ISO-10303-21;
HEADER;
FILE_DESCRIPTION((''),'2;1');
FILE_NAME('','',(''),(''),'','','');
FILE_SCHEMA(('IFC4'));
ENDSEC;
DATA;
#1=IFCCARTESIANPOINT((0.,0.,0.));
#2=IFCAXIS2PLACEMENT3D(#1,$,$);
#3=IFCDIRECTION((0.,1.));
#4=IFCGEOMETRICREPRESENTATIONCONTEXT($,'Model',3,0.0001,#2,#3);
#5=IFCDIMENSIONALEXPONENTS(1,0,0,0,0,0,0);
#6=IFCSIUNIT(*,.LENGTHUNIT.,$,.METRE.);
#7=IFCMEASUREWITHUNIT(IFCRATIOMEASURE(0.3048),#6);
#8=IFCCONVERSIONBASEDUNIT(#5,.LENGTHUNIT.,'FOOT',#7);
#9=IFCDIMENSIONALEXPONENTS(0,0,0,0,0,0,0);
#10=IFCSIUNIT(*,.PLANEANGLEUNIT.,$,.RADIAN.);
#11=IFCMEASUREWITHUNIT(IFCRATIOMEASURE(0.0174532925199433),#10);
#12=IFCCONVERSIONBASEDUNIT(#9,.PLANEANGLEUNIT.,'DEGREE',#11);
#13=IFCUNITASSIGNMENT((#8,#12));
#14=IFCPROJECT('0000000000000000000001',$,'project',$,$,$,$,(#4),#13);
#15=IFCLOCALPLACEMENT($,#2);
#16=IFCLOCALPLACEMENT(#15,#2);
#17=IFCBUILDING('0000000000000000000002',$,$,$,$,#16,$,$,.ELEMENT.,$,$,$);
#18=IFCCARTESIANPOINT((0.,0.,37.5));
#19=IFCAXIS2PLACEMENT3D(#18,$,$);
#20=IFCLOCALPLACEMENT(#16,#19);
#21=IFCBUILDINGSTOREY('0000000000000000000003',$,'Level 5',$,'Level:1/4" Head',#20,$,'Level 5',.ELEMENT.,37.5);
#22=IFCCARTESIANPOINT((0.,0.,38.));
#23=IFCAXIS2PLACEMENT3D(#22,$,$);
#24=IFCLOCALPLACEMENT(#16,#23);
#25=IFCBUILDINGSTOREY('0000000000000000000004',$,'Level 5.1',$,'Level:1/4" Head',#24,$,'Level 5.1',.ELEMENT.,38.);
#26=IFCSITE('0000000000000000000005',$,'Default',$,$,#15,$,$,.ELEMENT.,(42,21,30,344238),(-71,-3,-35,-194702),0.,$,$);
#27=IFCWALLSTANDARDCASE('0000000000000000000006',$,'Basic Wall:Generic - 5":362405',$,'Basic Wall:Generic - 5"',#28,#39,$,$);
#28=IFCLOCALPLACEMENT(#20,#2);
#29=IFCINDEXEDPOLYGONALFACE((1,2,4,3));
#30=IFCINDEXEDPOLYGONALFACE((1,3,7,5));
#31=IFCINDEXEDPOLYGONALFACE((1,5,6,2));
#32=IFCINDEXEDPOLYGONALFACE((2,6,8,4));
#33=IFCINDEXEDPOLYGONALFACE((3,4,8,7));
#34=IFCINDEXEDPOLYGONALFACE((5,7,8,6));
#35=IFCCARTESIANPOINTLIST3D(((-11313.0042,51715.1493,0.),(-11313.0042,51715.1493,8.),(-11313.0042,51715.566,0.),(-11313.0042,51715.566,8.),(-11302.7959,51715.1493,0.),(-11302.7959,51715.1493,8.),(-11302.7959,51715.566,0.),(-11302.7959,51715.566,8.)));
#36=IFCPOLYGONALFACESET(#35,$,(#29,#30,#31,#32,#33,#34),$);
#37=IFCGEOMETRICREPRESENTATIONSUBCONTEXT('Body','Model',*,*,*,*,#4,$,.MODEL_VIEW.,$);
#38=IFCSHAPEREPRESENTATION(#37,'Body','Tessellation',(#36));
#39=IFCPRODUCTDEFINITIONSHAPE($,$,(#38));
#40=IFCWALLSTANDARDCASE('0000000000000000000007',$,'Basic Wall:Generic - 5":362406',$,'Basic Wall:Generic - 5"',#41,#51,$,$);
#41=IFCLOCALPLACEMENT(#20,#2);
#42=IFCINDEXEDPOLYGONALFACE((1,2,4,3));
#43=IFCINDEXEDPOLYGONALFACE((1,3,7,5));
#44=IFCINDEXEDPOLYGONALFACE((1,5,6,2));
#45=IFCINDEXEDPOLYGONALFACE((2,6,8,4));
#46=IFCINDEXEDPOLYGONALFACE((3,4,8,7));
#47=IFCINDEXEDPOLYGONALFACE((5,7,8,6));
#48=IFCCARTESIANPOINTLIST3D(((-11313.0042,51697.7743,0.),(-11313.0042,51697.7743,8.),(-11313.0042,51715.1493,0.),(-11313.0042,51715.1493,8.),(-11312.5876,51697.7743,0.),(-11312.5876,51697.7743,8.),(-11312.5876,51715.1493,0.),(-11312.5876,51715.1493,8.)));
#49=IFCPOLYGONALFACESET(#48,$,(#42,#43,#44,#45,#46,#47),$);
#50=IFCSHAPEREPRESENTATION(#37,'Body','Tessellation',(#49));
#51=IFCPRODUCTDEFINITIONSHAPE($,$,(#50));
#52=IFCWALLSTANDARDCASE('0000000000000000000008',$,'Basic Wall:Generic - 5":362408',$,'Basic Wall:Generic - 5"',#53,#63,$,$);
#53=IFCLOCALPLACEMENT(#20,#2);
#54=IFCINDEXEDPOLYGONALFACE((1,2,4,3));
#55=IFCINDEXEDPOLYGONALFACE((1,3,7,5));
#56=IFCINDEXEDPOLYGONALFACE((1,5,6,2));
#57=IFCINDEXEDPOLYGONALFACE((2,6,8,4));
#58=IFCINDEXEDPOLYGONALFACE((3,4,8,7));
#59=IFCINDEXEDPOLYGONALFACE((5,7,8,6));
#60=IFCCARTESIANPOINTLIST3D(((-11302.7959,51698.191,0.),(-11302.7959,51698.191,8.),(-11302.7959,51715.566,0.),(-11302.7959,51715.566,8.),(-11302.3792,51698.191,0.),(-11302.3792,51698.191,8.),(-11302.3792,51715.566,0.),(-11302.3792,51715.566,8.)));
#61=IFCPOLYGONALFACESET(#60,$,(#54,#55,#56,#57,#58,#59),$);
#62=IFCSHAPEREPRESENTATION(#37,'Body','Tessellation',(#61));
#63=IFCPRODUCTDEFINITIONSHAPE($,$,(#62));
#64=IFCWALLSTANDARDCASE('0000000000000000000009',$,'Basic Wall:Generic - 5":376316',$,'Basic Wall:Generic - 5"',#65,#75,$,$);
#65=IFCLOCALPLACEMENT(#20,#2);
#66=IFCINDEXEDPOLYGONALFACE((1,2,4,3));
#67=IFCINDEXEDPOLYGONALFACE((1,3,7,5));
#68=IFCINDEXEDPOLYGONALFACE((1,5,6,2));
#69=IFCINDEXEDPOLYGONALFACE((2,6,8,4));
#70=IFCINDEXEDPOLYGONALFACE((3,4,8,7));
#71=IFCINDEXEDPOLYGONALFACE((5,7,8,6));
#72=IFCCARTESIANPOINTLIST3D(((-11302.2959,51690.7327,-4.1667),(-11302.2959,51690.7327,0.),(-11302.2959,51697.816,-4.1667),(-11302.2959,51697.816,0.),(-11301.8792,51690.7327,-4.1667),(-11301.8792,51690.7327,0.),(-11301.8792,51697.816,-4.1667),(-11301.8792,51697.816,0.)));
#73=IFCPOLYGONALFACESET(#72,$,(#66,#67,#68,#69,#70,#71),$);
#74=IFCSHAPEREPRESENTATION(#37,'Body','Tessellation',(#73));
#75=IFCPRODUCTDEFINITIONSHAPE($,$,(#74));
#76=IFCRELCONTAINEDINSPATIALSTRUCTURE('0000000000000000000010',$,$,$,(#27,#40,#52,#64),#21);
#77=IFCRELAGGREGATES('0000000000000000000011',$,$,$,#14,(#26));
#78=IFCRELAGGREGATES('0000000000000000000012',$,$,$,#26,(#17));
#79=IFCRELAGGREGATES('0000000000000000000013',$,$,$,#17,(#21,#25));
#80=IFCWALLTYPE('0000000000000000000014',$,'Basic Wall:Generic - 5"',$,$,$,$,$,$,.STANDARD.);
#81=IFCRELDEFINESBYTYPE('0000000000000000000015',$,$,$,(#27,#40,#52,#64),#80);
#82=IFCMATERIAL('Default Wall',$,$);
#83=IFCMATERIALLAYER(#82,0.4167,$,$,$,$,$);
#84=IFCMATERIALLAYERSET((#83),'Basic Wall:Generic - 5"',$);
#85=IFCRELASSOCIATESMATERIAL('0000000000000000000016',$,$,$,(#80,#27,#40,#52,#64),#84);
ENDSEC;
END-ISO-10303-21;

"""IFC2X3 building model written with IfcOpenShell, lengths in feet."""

from ifc_helpers import new_model, entity, si_unit, converted_unit, direction, frame, frame_2d, origin, place, context, subcontext, project, spatial, rectangle, extrude, material, layer, layer_set, layer_usage, type_object, element, save


model = new_model("IFC2X3")

# Units and contexts
model_context = context("Model", 3, precision=0.0001, world=origin(), true_north=direction((0.0, 1.0)))
body_context = subcontext(model_context, "Body", "Model", "MODEL_VIEW")
ifc_project = project(units=[converted_unit("LENGTHUNIT", "FOOT", entity("IfcRatioMeasure", 0.3048), si_unit("LENGTHUNIT", "METRE"), dimensions=[1, 0, 0, 0, 0, 0, 0]), converted_unit("PLANEANGLEUNIT", "DEGREE", entity("IfcRatioMeasure", 0.0174532925199433), si_unit("PLANEANGLEUNIT", "RADIAN"), dimensions=[0, 0, 0, 0, 0, 0, 0])], contexts=[model_context])

# Site, building, storey
site_placement = place(None, origin())
site = spatial("IfcSite", under=ifc_project, at=site_placement, Name="Default", CompositionType="ELEMENT", RefLatitude=(42, 21, 30, 344238), RefLongitude=(-71, -3, -35, -194702), RefElevation=0.0)
building_placement = place(site_placement, origin())
building = spatial("IfcBuilding", under=site, at=building_placement, CompositionType="ELEMENT")
storey_1_placement = place(building_placement, frame((0.0, 0.0, 37.5)))
storey_1 = spatial("IfcBuildingStorey", under=building, at=storey_1_placement, Name="Level 5", ObjectType="Level:1/4\" Head", LongName="Level 5", CompositionType="ELEMENT", Elevation=37.5)

# Walls
ifc_material_1 = material(Name="Default Wall")
ifc_layer = layer(ifc_material_1, 0.4167)
ifc_layer_set = layer_set([ifc_layer], Name="Basic Wall:Generic - 5\"")
ifc_layer_usage_1 = layer_usage(ifc_layer_set, "AXIS2", "POSITIVE", -0.2083)
wall_type = type_object("IfcWallType", Name="Basic Wall:Generic - 5\"", PredefinedType="STANDARD", material=ifc_layer_set)
wall_1_placement = place(storey_1_placement, frame((-11313.0042, 51715.3577, 0.0)))
element("IfcWallStandardCase", 1, at=wall_1_placement, inside=storey_1, type_object=wall_type, material=ifc_layer_usage_1, Name="Basic Wall:Generic - 5\":362405", ObjectType="Basic Wall:Generic - 5\"", context=body_context, shape_type="SweptSolid", body=[
    extrude(rectangle(XDim=10.2083, YDim=0.4167, at=frame_2d((5.1042, 0.0), x_axis=(-1.0, 0.0))), origin(), (0.0, 0.0, 1.0), 8.0),
])
ifc_layer_usage_2 = layer_usage(ifc_layer_set, "AXIS2", "POSITIVE", -0.2083)
wall_2_placement = place(storey_1_placement, frame((-11312.7959, 51697.7743, 0.0), z_axis=(0.0, 0.0, 1.0), x_axis=(0.0, 1.0, 0.0)))
element("IfcWallStandardCase", 2, at=wall_2_placement, inside=storey_1, type_object=wall_type, material=ifc_layer_usage_2, Name="Basic Wall:Generic - 5\":362406", ObjectType="Basic Wall:Generic - 5\"", context=body_context, shape_type="SweptSolid", body=[
    extrude(rectangle(XDim=17.375, YDim=0.4167, at=frame_2d((8.6875, 0.0), x_axis=(-1.0, 0.0))), origin(), (0.0, 0.0, 1.0), 8.0),
])

# Shared definitions
storey_2_placement = place(building_placement, frame((0.0, 0.0, 38.0)))
storey_2 = spatial("IfcBuildingStorey", under=building, at=storey_2_placement, Name="Level 5.1", ObjectType="Level:1/4\" Head", LongName="Level 5.1", CompositionType="ELEMENT", Elevation=38.0)

# Walls
ifc_layer_usage_3 = layer_usage(ifc_layer_set, "AXIS2", "POSITIVE", -0.2083)
wall_3_placement = place(storey_1_placement, frame((-11302.5876, 51715.566, 0.0), z_axis=(0.0, 0.0, 1.0), x_axis=(0.0, -1.0, 0.0)))
element("IfcWallStandardCase", 3, at=wall_3_placement, inside=storey_1, type_object=wall_type, material=ifc_layer_usage_3, Name="Basic Wall:Generic - 5\":362408", ObjectType="Basic Wall:Generic - 5\"", context=body_context, shape_type="SweptSolid", body=[
    extrude(rectangle(XDim=17.375, YDim=0.4167, at=frame_2d((8.6875, 0.0), x_axis=(-1.0, 0.0))), origin(), (0.0, 0.0, 1.0), 8.0),
])
ifc_layer_usage_4 = layer_usage(ifc_layer_set, "AXIS2", "POSITIVE", -0.2083)
wall_4_placement = place(storey_1_placement, frame((-11302.0876, 51690.7327, -4.1667), z_axis=(0.0, 0.0, 1.0), x_axis=(0.0, 1.0, 0.0)))
element("IfcWallStandardCase", 4, at=wall_4_placement, inside=storey_1, type_object=wall_type, material=ifc_layer_usage_4, Name="Basic Wall:Generic - 5\":376316", ObjectType="Basic Wall:Generic - 5\"", context=body_context, shape_type="SweptSolid", body=[
    extrude(rectangle(XDim=7.0833, YDim=0.4167, at=frame_2d((3.5417, 0.0), x_axis=(-1.0, 0.0))), origin(), (0.0, 0.0, 1.0), 4.1667),
])

save(model, "model.ifc")
